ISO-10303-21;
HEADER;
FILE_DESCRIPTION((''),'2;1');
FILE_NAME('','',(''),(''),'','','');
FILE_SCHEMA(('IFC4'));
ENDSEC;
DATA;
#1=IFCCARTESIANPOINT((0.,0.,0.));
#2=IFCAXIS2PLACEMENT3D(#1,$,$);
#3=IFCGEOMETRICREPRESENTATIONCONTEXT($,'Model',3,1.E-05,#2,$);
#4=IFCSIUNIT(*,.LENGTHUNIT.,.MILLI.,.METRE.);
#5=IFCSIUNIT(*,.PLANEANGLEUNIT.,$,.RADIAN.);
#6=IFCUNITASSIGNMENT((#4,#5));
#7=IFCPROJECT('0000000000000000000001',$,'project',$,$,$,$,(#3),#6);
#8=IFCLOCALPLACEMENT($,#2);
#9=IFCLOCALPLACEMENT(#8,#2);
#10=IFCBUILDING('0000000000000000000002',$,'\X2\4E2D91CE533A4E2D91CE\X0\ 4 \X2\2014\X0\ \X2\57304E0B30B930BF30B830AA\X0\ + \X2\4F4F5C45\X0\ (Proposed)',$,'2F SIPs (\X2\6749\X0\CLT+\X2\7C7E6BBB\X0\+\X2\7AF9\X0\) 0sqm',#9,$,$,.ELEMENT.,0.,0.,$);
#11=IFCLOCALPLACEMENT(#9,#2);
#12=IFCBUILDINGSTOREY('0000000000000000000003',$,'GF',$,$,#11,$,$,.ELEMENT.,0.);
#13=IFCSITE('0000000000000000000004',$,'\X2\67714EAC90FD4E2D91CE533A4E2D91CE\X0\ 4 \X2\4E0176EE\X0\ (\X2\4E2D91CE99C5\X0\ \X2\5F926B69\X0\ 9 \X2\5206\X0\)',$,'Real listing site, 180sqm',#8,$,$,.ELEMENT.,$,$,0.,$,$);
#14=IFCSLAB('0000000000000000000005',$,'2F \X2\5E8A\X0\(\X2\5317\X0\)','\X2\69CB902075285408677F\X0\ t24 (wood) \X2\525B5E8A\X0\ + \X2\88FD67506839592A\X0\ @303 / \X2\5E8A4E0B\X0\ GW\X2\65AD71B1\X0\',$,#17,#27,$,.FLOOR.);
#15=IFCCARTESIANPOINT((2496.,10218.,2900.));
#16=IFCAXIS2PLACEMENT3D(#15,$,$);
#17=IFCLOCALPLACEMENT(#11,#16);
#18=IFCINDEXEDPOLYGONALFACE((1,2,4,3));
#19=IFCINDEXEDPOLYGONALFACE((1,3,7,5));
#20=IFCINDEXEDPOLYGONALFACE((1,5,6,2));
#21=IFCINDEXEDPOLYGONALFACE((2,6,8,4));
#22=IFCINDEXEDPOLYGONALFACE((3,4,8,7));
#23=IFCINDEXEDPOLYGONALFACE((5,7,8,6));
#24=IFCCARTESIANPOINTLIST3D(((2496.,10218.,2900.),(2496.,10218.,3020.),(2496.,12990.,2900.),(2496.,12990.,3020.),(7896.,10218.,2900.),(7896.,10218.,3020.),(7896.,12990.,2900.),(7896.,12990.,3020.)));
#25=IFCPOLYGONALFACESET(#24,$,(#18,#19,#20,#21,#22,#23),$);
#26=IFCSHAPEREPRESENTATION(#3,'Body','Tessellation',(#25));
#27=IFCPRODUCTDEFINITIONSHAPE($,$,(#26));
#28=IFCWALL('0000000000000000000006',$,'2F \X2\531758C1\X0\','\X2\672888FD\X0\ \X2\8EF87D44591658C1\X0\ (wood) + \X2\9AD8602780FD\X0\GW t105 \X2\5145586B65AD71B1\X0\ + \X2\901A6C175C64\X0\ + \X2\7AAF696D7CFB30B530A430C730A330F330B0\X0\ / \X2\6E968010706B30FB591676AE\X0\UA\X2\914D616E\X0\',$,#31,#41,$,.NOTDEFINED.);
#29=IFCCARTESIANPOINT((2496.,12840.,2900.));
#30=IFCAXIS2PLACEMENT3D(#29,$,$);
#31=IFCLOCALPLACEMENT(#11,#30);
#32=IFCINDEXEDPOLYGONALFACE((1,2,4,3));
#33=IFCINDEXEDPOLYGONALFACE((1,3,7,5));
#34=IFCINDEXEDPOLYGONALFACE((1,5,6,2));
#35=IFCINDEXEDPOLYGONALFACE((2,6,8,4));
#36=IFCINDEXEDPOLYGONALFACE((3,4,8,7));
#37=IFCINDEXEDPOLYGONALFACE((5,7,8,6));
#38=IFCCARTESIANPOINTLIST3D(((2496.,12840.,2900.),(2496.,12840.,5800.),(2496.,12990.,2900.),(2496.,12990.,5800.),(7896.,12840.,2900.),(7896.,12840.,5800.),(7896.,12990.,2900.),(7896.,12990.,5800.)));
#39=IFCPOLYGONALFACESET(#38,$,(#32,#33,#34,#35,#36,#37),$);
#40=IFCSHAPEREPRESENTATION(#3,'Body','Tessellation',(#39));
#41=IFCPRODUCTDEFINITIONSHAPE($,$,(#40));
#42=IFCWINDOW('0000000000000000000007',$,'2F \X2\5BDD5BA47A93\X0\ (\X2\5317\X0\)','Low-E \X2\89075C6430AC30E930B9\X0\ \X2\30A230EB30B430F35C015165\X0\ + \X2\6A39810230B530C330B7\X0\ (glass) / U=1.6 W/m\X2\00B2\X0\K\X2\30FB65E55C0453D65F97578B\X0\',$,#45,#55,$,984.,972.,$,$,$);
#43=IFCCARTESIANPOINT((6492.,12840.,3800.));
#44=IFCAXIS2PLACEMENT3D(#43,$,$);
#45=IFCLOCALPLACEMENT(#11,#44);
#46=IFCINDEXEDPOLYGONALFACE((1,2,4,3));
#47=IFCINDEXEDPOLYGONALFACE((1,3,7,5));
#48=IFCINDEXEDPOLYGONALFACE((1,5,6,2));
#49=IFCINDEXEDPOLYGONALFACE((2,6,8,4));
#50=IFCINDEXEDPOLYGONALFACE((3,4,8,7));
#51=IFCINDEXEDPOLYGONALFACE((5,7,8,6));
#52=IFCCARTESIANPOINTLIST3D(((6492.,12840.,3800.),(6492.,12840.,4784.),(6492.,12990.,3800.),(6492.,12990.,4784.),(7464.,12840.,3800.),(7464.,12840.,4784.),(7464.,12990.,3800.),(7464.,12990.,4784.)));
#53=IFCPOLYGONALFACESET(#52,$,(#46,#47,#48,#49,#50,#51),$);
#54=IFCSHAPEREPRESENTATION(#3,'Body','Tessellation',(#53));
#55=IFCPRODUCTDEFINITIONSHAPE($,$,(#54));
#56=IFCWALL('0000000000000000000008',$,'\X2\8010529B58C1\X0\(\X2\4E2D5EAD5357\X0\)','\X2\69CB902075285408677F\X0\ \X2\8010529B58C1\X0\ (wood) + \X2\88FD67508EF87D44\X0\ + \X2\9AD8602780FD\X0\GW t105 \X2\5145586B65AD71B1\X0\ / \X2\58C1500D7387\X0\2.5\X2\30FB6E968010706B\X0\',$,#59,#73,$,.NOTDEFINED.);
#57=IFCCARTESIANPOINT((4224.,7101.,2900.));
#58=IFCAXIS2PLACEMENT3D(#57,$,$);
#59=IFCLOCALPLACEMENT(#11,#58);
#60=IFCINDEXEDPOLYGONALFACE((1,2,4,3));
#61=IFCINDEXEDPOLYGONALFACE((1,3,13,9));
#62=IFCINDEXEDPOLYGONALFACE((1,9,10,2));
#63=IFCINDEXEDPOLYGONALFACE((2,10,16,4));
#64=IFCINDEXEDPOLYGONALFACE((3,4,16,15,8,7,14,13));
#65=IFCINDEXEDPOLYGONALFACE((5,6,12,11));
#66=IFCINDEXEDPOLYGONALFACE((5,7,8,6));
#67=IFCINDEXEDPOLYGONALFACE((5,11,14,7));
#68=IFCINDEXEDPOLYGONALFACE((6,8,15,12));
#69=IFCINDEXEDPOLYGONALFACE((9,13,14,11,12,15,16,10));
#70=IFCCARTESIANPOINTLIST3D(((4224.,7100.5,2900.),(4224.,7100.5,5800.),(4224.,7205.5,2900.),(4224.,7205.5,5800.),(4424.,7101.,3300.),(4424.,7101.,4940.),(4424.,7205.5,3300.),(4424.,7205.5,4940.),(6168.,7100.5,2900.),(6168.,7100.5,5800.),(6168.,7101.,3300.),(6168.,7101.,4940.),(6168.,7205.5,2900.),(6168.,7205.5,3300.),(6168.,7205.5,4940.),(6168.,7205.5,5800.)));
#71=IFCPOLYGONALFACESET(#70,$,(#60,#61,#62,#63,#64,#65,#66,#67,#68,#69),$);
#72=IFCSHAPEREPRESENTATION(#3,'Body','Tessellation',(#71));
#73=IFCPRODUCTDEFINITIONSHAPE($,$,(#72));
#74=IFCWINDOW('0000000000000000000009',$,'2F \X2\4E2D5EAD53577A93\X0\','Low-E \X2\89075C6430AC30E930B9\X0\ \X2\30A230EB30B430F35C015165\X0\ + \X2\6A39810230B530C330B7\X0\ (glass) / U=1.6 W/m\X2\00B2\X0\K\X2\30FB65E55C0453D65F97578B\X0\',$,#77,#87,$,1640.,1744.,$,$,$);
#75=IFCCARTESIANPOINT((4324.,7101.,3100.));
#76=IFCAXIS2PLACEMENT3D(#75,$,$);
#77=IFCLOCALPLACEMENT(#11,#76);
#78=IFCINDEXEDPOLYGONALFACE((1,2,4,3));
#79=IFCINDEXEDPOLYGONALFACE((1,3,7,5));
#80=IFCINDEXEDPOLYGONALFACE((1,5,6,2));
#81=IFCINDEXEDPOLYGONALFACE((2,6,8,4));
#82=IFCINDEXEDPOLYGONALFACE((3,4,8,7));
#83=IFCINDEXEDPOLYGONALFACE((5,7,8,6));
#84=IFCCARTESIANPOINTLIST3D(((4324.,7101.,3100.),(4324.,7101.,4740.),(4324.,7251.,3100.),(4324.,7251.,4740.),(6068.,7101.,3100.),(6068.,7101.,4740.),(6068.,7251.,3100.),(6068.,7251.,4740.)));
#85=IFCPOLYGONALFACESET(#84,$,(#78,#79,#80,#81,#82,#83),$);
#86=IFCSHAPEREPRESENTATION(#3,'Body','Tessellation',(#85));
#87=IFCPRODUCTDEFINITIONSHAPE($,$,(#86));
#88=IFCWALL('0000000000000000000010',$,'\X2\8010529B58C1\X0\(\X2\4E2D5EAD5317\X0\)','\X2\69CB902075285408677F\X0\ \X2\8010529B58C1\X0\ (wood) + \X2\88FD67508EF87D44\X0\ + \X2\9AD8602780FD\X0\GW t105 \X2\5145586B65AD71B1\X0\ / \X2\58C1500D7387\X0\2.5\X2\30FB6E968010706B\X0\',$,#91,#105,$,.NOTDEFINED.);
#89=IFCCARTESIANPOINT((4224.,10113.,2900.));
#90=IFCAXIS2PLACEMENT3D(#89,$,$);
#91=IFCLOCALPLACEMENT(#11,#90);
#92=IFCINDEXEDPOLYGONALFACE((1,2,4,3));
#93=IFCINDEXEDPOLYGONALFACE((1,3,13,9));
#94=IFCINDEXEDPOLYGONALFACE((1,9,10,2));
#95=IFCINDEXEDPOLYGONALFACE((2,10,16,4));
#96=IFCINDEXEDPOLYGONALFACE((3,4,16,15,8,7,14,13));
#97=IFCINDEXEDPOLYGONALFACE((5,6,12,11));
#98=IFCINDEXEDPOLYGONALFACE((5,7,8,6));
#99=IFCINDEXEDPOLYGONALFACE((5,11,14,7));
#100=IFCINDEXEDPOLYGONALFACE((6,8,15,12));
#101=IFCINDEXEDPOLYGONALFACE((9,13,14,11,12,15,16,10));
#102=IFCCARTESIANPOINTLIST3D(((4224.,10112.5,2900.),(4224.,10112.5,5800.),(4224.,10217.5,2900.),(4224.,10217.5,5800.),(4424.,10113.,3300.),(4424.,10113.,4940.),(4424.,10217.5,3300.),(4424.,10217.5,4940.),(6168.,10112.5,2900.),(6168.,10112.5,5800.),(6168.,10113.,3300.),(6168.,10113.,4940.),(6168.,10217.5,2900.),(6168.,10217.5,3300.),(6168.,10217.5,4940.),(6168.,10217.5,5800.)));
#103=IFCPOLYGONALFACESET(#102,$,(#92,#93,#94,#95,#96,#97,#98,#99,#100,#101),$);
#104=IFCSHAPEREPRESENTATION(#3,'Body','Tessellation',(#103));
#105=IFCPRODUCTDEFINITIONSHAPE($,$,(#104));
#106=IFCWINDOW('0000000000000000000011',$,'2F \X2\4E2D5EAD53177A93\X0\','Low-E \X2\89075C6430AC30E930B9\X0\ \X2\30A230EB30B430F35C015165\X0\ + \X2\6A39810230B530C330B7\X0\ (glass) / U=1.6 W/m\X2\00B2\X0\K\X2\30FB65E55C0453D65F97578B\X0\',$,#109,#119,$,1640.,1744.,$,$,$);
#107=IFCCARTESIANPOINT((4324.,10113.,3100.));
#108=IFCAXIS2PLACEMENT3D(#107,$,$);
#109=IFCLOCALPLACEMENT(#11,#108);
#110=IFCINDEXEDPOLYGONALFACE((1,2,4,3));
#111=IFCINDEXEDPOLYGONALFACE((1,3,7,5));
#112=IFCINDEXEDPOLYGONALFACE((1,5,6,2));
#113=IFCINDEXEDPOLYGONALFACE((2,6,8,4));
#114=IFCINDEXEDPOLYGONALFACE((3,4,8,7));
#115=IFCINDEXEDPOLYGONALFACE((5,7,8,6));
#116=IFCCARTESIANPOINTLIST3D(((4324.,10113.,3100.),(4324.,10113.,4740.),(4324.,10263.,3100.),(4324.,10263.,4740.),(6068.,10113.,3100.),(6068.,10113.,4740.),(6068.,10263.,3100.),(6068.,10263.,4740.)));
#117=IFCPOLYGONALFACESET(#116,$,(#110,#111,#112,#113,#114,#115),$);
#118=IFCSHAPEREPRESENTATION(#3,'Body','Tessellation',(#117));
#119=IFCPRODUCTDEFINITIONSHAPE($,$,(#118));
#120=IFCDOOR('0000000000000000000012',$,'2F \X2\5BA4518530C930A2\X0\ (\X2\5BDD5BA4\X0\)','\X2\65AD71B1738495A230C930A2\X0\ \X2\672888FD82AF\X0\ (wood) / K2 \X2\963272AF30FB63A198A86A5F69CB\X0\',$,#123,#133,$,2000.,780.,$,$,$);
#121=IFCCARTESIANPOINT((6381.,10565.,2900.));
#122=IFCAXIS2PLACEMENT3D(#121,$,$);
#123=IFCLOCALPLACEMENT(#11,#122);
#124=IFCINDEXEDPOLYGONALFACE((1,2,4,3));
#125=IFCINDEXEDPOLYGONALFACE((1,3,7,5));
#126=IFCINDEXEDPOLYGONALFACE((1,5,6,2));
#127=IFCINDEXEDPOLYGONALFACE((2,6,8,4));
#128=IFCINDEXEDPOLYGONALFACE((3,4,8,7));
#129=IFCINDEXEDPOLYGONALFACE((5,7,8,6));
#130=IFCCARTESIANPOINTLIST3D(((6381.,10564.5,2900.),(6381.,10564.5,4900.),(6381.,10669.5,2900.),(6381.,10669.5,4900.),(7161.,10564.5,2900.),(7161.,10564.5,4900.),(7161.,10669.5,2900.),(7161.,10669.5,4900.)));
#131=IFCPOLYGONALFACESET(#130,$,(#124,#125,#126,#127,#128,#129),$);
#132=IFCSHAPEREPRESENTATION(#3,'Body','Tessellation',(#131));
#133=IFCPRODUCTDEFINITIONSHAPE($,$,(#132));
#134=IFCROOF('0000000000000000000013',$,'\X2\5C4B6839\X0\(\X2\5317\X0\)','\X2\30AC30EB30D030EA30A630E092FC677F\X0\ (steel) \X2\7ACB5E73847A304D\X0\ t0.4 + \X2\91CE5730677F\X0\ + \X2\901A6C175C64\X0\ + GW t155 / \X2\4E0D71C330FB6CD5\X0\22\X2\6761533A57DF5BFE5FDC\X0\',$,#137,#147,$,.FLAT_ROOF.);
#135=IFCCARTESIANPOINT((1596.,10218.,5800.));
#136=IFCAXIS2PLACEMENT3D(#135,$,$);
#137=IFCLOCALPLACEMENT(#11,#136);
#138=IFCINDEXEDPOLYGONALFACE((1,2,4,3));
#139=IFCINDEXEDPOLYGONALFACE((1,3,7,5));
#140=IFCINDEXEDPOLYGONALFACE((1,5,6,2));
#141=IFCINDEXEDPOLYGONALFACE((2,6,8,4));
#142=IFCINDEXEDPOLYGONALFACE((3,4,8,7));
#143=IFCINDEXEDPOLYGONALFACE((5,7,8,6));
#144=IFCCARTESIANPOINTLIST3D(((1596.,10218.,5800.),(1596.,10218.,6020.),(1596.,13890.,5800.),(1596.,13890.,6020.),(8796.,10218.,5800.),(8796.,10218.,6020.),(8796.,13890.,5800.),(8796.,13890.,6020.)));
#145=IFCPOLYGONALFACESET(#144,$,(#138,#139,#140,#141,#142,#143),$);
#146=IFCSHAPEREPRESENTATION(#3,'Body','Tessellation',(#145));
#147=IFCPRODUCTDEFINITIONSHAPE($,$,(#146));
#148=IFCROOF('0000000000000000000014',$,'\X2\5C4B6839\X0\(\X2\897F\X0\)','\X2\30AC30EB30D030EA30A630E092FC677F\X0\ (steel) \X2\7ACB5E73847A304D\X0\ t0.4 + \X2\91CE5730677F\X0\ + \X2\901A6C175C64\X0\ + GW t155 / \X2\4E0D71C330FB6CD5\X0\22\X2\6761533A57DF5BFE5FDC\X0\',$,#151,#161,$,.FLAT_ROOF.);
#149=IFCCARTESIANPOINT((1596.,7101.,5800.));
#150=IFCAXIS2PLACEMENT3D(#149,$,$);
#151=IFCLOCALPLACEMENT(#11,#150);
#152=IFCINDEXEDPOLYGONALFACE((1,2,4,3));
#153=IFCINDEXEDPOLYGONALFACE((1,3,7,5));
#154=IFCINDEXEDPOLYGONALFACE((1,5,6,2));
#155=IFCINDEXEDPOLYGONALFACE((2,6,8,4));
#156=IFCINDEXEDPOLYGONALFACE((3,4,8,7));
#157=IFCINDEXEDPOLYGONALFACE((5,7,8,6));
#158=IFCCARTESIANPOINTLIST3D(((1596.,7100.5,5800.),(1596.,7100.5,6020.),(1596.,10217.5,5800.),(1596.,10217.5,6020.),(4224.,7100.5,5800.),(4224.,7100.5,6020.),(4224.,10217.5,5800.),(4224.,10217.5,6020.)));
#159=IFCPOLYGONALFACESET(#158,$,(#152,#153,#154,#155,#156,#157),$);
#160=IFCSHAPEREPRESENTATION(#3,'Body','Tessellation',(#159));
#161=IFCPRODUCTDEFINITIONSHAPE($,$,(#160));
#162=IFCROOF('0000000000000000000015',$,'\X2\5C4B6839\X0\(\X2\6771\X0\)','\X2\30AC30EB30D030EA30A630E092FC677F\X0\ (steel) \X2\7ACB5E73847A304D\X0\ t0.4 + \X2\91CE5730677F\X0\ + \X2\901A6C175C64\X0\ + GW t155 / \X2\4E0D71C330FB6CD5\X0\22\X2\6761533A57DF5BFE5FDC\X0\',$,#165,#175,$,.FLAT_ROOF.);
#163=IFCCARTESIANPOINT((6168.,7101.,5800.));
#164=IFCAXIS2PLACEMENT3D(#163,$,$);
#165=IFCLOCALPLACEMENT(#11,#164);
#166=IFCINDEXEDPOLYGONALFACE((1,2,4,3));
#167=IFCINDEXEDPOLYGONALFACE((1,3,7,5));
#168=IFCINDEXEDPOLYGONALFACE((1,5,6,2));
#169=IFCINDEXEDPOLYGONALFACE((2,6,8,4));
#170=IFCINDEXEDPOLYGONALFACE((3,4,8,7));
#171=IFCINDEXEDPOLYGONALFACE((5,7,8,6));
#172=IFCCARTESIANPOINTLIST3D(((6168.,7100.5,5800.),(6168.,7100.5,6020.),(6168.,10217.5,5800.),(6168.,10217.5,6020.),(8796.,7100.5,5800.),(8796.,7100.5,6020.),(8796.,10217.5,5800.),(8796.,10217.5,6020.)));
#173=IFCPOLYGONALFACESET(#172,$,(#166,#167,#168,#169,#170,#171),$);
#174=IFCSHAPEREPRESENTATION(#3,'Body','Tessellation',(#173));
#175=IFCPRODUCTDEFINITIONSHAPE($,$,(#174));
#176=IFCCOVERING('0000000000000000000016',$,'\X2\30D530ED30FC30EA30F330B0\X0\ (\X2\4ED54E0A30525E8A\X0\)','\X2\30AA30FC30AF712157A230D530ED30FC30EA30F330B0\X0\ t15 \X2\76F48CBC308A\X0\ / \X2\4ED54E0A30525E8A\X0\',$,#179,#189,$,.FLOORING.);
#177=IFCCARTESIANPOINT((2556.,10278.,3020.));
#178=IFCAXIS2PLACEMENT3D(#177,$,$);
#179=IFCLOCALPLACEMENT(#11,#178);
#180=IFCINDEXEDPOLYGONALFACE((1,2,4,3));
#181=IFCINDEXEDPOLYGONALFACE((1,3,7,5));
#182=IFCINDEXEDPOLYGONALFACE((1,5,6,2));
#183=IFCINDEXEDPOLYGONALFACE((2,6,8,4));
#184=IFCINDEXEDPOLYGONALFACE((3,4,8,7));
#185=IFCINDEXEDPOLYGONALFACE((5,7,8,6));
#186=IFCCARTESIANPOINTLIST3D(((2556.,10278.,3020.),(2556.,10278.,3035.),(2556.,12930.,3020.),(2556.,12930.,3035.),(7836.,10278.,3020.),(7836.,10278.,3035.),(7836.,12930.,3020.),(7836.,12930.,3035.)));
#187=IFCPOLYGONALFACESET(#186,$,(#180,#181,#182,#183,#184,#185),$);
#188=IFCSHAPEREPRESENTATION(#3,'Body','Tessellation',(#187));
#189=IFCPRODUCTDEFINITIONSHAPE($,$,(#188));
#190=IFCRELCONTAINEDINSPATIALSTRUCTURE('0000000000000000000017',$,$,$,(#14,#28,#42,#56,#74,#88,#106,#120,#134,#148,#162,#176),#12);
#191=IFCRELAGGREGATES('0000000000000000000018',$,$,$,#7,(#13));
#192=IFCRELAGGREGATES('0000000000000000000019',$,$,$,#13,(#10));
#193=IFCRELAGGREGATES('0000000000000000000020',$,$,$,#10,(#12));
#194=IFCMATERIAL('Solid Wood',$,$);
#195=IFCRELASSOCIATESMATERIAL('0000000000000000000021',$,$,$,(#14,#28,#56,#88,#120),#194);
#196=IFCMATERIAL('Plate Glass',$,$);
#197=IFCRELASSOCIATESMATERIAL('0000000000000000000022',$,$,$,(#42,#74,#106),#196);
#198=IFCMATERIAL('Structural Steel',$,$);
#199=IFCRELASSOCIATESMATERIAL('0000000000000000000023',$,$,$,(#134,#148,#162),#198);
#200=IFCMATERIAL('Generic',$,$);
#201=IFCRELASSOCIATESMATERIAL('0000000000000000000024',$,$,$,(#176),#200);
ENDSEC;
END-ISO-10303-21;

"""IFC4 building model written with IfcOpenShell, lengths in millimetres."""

from ifc_helpers import new_model, si_unit, frame, frame_2d, origin, place, context, project, spatial, rectangle, extrude, material, element, fill, save


model = new_model("IFC4")

# Units and contexts
model_context = context("Model", 3, precision=1e-05, world=origin())
ifc_project = project(units=[si_unit("LENGTHUNIT", "METRE", prefix="MILLI"), si_unit("PLANEANGLEUNIT", "RADIAN")], contexts=[model_context])

# Site, building, storey
site_placement = place(None, origin())
site = spatial("IfcSite", under=ifc_project, at=site_placement, Name="東京都中野区中野 4 丁目 (中野駅 徒歩 9 分)", ObjectType="Real listing site, 180sqm", CompositionType="ELEMENT", RefElevation=0.0)
building_placement = place(site_placement, origin())
building = spatial("IfcBuilding", under=site, at=building_placement, Name="中野区中野 4 — 地下スタジオ + 住居 (Proposed)", ObjectType="2F SIPs (杉CLT+籾殻+竹) 0sqm", CompositionType="ELEMENT", ElevationOfRefHeight=0.0, ElevationOfTerrain=0.0)
storey_placement = place(building_placement, origin())
storey = spatial("IfcBuildingStorey", under=building, at=storey_placement, Name="GF", CompositionType="ELEMENT", Elevation=0.0)

# Slab
ifc_material_1 = material(Name="Solid Wood")
slab_placement = place(storey_placement, frame((2496.0, 10218.0, 2900.0)))
element("IfcSlab", 1, at=slab_placement, inside=storey, material=ifc_material_1, Name="2F 床(北)", Description="構造用合板 t24 (wood) 剛床 + 製材根太 @303 / 床下 GW断熱", PredefinedType="FLOOR", context=model_context, shape_type="SweptSolid", body=[
    extrude(rectangle(XDim=5400.0, YDim=2772.0, at=frame_2d((2700.0, 1386.0))), frame((2496.0, 10218.0, 2900.0)), (0.0, 0.0, 1.0), 120.0),
])

# Walls, openings, windows
wall_1_placement = place(storey_placement, frame((2496.0, 12840.0, 2900.0)))
wall_1 = element("IfcWall", 2, at=wall_1_placement, inside=storey, material=ifc_material_1, Name="2F 北壁", Description="木製 軸組外壁 (wood) + 高性能GW t105 充填断熱 + 通気層 + 窯業系サイディング / 準耐火・外皮UA配慮", PredefinedType="NOTDEFINED", context=model_context, shape_type="SweptSolid", body=[
    extrude(rectangle(XDim=5400.0, YDim=150.0, at=frame_2d((2700.0, 75.0))), frame((2496.0, 12840.0, 2900.0)), (0.0, 0.0, 1.0), 2900.0),
])
opening_1_placement = place(storey_placement, frame((6492.0, 12840.0, 3800.0)))
opening_1 = element("IfcOpeningElement", 3, at=opening_1_placement, cuts=wall_1, PredefinedType="NOTDEFINED", context=model_context, shape_type="SweptSolid", body=[
    extrude(rectangle(XDim=972.0, YDim=150.0, at=frame_2d((486.0, 75.0))), frame((6492.0, 12840.0, 3800.0)), (0.0, 0.0, 1.0), 984.0),
])
ifc_material_2 = material(Name="Plate Glass")
window_1_placement = place(storey_placement, frame((6492.0, 12840.0, 3800.0)))
window_1 = element("IfcWindow", 4, at=window_1_placement, inside=storey, material=ifc_material_2, Name="2F 寝室窓 (北)", Description="Low-E 複層ガラス アルゴン封入 + 樹脂サッシ (glass) / U=1.6 W/m²K・日射取得型", OverallHeight=984.0, OverallWidth=972.0, context=model_context, shape_type="SweptSolid", body=[
    extrude(rectangle(XDim=972.0, YDim=150.0, at=frame_2d((486.0, 75.0))), frame((6492.0, 12840.0, 3800.0)), (0.0, 0.0, 1.0), 984.0),
])
fill(opening_1, window_1)
wall_2_placement = place(storey_placement, frame((4224.0, 7101.0, 2900.0)))
wall_2 = element("IfcWall", 5, at=wall_2_placement, inside=storey, material=ifc_material_1, Name="耐力壁(中庭南)", Description="構造用合板 耐力壁 (wood) + 製材軸組 + 高性能GW t105 充填断熱 / 壁倍率2.5・準耐火", PredefinedType="NOTDEFINED", context=model_context, shape_type="SweptSolid", body=[
    extrude(rectangle(XDim=1944.0, YDim=105.0, at=frame_2d((972.0, 52.0))), frame((4224.0, 7101.0, 2900.0)), (0.0, 0.0, 1.0), 2900.0),
])
opening_2_placement = place(storey_placement, frame((4324.0, 7101.0, 3100.0)))
opening_2 = element("IfcOpeningElement", 6, at=opening_2_placement, cuts=wall_2, PredefinedType="NOTDEFINED", context=model_context, shape_type="SweptSolid", body=[
    extrude(rectangle(XDim=1744.0, YDim=150.0, at=frame_2d((872.0, 75.0))), frame((4324.0, 7101.0, 3100.0)), (0.0, 0.0, 1.0), 1640.0),
])
window_2_placement = place(storey_placement, frame((4324.0, 7101.0, 3100.0)))
window_2 = element("IfcWindow", 7, at=window_2_placement, inside=storey, material=ifc_material_2, Name="2F 中庭南窓", Description="Low-E 複層ガラス アルゴン封入 + 樹脂サッシ (glass) / U=1.6 W/m²K・日射取得型", OverallHeight=1640.0, OverallWidth=1744.0, context=model_context, shape_type="SweptSolid", body=[
    extrude(rectangle(XDim=1744.0, YDim=150.0, at=frame_2d((872.0, 75.0))), frame((4324.0, 7101.0, 3100.0)), (0.0, 0.0, 1.0), 1640.0),
])
fill(opening_2, window_2)
wall_3_placement = place(storey_placement, frame((4224.0, 10113.0, 2900.0)))
wall_3 = element("IfcWall", 8, at=wall_3_placement, inside=storey, material=ifc_material_1, Name="耐力壁(中庭北)", Description="構造用合板 耐力壁 (wood) + 製材軸組 + 高性能GW t105 充填断熱 / 壁倍率2.5・準耐火", PredefinedType="NOTDEFINED", context=model_context, shape_type="SweptSolid", body=[
    extrude(rectangle(XDim=1944.0, YDim=105.0, at=frame_2d((972.0, 52.0))), frame((4224.0, 10113.0, 2900.0)), (0.0, 0.0, 1.0), 2900.0),
])
opening_3_placement = place(storey_placement, frame((4324.0, 10113.0, 3100.0)))
opening_3 = element("IfcOpeningElement", 9, at=opening_3_placement, cuts=wall_3, PredefinedType="NOTDEFINED", context=model_context, shape_type="SweptSolid", body=[
    extrude(rectangle(XDim=1744.0, YDim=150.0, at=frame_2d((872.0, 75.0))), frame((4324.0, 10113.0, 3100.0)), (0.0, 0.0, 1.0), 1640.0),
])
window_3_placement = place(storey_placement, frame((4324.0, 10113.0, 3100.0)))
window_3 = element("IfcWindow", 10, at=window_3_placement, inside=storey, material=ifc_material_2, Name="2F 中庭北窓", Description="Low-E 複層ガラス アルゴン封入 + 樹脂サッシ (glass) / U=1.6 W/m²K・日射取得型", OverallHeight=1640.0, OverallWidth=1744.0, context=model_context, shape_type="SweptSolid", body=[
    extrude(rectangle(XDim=1744.0, YDim=150.0, at=frame_2d((872.0, 75.0))), frame((4324.0, 10113.0, 3100.0)), (0.0, 0.0, 1.0), 1640.0),
])
fill(opening_3, window_3)

# Door
door_placement = place(storey_placement, frame((6381.0, 10565.0, 2900.0)))
element("IfcDoor", 11, at=door_placement, inside=storey, material=ifc_material_1, Name="2F 室内ドア (寝室)", Description="断熱玄関ドア 木製芯 (wood) / K2 防犯・採風機構", OverallHeight=2000.0, OverallWidth=780.0, context=model_context, shape_type="SweptSolid", body=[
    extrude(rectangle(XDim=780.0, YDim=105.0, at=frame_2d((390.0, 52.0))), frame((6381.0, 10565.0, 2900.0)), (0.0, 0.0, 1.0), 2000.0),
])

# Roofs
ifc_material_3 = material(Name="Structural Steel")
for number, where, name in (
    (12, (1596.0, 10218.0, 5800.0), "屋根(北)"),
):
    element("IfcRoof", number, at=place(storey_placement, frame(where)), inside=storey, material=ifc_material_3, Name=name, Description="ガルバリウム鋼板 (steel) 立平葺き t0.4 + 野地板 + 通気層 + GW t155 / 不燃・法22条区域対応", PredefinedType="FLAT_ROOF", context=model_context, shape_type="SweptSolid", body=[
        extrude(rectangle(XDim=7200.0, YDim=3672.0, at=frame_2d((3600.0, 1836.0))), frame((1596.0, 10218.0, 5800.0)), (0.0, 0.0, 1.0), 220.0),
    ])
roof_1_placement = place(storey_placement, frame((1596.0, 7101.0, 5800.0)))
element("IfcRoof", 13, at=roof_1_placement, inside=storey, material=ifc_material_3, Name="屋根(西)", Description="ガルバリウム鋼板 (steel) 立平葺き t0.4 + 野地板 + 通気層 + GW t155 / 不燃・法22条区域対応", PredefinedType="FLAT_ROOF", context=model_context, shape_type="SweptSolid", body=[
    extrude(rectangle(XDim=2628.0, YDim=3117.0, at=frame_2d((1314.0, 1558.0))), frame((1596.0, 7101.0, 5800.0)), (0.0, 0.0, 1.0), 220.0),
])
roof_2_placement = place(storey_placement, frame((6168.0, 7101.0, 5800.0)))
element("IfcRoof", 14, at=roof_2_placement, inside=storey, material=ifc_material_3, Name="屋根(東)", Description="ガルバリウム鋼板 (steel) 立平葺き t0.4 + 野地板 + 通気層 + GW t155 / 不燃・法22条区域対応", PredefinedType="FLAT_ROOF", context=model_context, shape_type="SweptSolid", body=[
    extrude(rectangle(XDim=2628.0, YDim=3117.0, at=frame_2d((1314.0, 1558.0))), frame((6168.0, 7101.0, 5800.0)), (0.0, 0.0, 1.0), 220.0),
])

# Covering
ifc_material_4 = material(Name="Generic")
covering_1_placement = place(storey_placement, frame((2556.0, 10278.0, 3020.0)))
element("IfcCovering", 15, at=covering_1_placement, inside=storey, material=ifc_material_4, Name="フローリング (仕上げ床)", Description="オーク無垢フローリング t15 直貼り / 仕上げ床", PredefinedType="FLOORING", context=model_context, shape_type="SweptSolid", body=[
    extrude(rectangle(XDim=5280.0, YDim=2652.0, at=frame_2d((2640.0, 1326.0))), frame((2556.0, 10278.0, 3020.0)), (0.0, 0.0, 1.0), 15.0),
])

save(model, "model.ifc")
